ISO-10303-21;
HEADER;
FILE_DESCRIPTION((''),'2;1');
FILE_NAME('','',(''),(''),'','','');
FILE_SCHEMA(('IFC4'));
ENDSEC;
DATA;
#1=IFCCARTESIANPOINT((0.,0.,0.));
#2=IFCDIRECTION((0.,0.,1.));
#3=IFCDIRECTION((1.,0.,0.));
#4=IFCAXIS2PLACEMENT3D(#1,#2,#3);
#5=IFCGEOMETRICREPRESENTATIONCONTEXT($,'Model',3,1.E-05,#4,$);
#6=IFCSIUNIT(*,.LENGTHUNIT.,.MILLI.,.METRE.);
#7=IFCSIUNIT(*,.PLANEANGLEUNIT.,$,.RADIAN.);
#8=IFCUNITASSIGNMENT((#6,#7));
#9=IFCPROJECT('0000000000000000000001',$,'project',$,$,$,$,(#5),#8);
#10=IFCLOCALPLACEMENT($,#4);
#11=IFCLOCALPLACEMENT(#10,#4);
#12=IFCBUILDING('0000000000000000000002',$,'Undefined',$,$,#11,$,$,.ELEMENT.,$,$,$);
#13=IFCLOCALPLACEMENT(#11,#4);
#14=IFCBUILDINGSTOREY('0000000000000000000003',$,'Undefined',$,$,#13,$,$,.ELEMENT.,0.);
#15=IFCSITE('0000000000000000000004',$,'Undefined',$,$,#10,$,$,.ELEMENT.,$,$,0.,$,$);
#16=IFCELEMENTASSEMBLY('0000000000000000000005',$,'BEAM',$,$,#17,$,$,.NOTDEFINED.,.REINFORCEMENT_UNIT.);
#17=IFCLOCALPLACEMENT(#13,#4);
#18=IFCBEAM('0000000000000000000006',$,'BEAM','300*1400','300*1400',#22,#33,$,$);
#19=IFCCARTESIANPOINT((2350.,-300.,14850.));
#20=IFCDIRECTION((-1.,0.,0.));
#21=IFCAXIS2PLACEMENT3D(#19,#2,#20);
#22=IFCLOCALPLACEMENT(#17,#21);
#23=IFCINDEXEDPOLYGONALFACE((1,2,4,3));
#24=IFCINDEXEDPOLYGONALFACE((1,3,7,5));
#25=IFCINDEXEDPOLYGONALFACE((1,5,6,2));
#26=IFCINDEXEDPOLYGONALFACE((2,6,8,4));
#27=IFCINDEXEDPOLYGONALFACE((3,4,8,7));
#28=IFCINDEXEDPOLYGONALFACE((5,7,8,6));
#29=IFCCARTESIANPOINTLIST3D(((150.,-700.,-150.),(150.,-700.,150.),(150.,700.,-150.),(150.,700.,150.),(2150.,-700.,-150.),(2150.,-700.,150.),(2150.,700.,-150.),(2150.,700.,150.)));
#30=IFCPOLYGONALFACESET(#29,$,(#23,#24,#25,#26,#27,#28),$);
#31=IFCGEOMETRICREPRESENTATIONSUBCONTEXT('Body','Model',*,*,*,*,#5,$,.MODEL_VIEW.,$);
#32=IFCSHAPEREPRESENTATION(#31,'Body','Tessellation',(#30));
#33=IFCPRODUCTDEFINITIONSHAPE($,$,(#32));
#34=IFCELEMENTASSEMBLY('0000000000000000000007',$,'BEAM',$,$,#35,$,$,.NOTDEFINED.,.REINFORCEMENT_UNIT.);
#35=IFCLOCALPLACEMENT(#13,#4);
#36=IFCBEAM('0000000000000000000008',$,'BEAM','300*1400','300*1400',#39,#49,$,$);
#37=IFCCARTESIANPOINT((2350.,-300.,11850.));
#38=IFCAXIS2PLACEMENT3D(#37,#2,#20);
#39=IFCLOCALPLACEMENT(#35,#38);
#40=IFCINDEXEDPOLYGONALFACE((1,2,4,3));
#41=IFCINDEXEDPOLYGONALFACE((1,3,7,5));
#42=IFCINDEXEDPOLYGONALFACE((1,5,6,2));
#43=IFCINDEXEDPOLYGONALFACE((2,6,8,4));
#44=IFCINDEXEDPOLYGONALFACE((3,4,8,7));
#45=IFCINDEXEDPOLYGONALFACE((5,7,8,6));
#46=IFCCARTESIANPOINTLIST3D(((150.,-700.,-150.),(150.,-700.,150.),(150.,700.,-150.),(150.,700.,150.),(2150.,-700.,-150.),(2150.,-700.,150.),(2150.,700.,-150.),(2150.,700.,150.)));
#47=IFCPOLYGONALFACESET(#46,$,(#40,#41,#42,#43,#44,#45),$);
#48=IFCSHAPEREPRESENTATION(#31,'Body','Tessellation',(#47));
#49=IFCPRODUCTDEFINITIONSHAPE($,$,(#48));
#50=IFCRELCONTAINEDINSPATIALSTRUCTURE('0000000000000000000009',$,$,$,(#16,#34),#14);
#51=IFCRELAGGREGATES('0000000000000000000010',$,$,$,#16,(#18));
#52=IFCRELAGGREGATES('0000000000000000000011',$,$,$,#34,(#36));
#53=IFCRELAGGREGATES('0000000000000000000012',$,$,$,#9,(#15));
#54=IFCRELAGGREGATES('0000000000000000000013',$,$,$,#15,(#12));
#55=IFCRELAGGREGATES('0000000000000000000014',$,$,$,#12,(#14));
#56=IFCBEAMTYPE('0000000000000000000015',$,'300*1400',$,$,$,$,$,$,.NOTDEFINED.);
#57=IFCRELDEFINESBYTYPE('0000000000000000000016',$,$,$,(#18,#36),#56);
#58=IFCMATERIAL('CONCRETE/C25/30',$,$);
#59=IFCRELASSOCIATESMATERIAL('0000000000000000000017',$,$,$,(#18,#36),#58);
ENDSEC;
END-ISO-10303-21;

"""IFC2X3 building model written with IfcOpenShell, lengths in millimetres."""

from ifc_helpers import new_model, si_unit, frame, origin_with_axes, origin_2d_with_axis, place, context, subcontext, project, spatial, rectangle, extrude, material, type_object, element, aggregate, save


model = new_model("IFC2X3")

# Units and contexts
model_context = context("Model", 3, precision=1e-05, world=origin_with_axes())
body_context = subcontext(model_context, "Body", "Model", "MODEL_VIEW")
ifc_project = project(units=[si_unit("LENGTHUNIT", "METRE", prefix="MILLI"), si_unit("PLANEANGLEUNIT", "RADIAN")], contexts=[model_context])

# Site, building, storey
site_placement = place(None, origin_with_axes())
site = spatial("IfcSite", under=ifc_project, at=site_placement, Name="Undefined", CompositionType="ELEMENT", RefElevation=0.0)
building_placement = place(site_placement, origin_with_axes())
building = spatial("IfcBuilding", under=site, at=building_placement, Name="Undefined", CompositionType="ELEMENT")
storey_placement = place(building_placement, origin_with_axes())
storey = spatial("IfcBuildingStorey", under=building, at=storey_placement, Name="Undefined", CompositionType="ELEMENT", Elevation=0.0)

# Shared definitions
ifc_material_1 = material(Name="CONCRETE/C25/30")

# Element assemblies, beams
assembly_1_placement = place(storey_placement, origin_with_axes())
assembly_1 = element("IfcElementAssembly", 1, at=assembly_1_placement, inside=storey, Name="BEAM", AssemblyPlace="NOTDEFINED", PredefinedType="REINFORCEMENT_UNIT")
beam_type_1 = type_object("IfcBeamType", Name="300*1400", PredefinedType="NOTDEFINED")
beam_1_placement = place(assembly_1_placement, frame((2350.0, -300.0, 14850.0), z_axis=(0.0, 0.0, 1.0), x_axis=(-1.0, 0.0, 0.0)))
beam_1 = element("IfcBeam", 2, at=beam_1_placement, type_object=beam_type_1, material=ifc_material_1, Name="BEAM", Description="300*1400", ObjectType="300*1400", context=body_context, shape_type="SweptSolid", body=[
    extrude(rectangle(XDim=1400.0, YDim=300.0, at=origin_2d_with_axis()), frame((2150.0, 0.0, 0.0), z_axis=(-1.0, 0.0, 0.0), x_axis=(0.0, -1.0, 0.0)), (0.0, 0.0, 1.0), 2000.0),
])
aggregate(assembly_1, [beam_1])
assembly_2_placement = place(storey_placement, origin_with_axes())
assembly_2 = element("IfcElementAssembly", 3, at=assembly_2_placement, inside=storey, Name="BEAM", AssemblyPlace="NOTDEFINED", PredefinedType="REINFORCEMENT_UNIT")
beam_2_placement = place(assembly_2_placement, frame((2350.0, -300.0, 11850.0), z_axis=(0.0, 0.0, 1.0), x_axis=(-1.0, 0.0, 0.0)))
beam_2 = element("IfcBeam", 4, at=beam_2_placement, type_object=beam_type_1, material=ifc_material_1, Name="BEAM", Description="300*1400", ObjectType="300*1400", context=body_context, shape_type="SweptSolid", body=[
    extrude(rectangle(XDim=1400.0, YDim=300.0, at=origin_2d_with_axis()), frame((2150.0, 0.0, 0.0), z_axis=(-1.0, 0.0, 0.0), x_axis=(0.0, -1.0, 0.0)), (0.0, 0.0, 1.0), 2000.0),
])
aggregate(assembly_2, [beam_2])

save(model, "model.ifc")
